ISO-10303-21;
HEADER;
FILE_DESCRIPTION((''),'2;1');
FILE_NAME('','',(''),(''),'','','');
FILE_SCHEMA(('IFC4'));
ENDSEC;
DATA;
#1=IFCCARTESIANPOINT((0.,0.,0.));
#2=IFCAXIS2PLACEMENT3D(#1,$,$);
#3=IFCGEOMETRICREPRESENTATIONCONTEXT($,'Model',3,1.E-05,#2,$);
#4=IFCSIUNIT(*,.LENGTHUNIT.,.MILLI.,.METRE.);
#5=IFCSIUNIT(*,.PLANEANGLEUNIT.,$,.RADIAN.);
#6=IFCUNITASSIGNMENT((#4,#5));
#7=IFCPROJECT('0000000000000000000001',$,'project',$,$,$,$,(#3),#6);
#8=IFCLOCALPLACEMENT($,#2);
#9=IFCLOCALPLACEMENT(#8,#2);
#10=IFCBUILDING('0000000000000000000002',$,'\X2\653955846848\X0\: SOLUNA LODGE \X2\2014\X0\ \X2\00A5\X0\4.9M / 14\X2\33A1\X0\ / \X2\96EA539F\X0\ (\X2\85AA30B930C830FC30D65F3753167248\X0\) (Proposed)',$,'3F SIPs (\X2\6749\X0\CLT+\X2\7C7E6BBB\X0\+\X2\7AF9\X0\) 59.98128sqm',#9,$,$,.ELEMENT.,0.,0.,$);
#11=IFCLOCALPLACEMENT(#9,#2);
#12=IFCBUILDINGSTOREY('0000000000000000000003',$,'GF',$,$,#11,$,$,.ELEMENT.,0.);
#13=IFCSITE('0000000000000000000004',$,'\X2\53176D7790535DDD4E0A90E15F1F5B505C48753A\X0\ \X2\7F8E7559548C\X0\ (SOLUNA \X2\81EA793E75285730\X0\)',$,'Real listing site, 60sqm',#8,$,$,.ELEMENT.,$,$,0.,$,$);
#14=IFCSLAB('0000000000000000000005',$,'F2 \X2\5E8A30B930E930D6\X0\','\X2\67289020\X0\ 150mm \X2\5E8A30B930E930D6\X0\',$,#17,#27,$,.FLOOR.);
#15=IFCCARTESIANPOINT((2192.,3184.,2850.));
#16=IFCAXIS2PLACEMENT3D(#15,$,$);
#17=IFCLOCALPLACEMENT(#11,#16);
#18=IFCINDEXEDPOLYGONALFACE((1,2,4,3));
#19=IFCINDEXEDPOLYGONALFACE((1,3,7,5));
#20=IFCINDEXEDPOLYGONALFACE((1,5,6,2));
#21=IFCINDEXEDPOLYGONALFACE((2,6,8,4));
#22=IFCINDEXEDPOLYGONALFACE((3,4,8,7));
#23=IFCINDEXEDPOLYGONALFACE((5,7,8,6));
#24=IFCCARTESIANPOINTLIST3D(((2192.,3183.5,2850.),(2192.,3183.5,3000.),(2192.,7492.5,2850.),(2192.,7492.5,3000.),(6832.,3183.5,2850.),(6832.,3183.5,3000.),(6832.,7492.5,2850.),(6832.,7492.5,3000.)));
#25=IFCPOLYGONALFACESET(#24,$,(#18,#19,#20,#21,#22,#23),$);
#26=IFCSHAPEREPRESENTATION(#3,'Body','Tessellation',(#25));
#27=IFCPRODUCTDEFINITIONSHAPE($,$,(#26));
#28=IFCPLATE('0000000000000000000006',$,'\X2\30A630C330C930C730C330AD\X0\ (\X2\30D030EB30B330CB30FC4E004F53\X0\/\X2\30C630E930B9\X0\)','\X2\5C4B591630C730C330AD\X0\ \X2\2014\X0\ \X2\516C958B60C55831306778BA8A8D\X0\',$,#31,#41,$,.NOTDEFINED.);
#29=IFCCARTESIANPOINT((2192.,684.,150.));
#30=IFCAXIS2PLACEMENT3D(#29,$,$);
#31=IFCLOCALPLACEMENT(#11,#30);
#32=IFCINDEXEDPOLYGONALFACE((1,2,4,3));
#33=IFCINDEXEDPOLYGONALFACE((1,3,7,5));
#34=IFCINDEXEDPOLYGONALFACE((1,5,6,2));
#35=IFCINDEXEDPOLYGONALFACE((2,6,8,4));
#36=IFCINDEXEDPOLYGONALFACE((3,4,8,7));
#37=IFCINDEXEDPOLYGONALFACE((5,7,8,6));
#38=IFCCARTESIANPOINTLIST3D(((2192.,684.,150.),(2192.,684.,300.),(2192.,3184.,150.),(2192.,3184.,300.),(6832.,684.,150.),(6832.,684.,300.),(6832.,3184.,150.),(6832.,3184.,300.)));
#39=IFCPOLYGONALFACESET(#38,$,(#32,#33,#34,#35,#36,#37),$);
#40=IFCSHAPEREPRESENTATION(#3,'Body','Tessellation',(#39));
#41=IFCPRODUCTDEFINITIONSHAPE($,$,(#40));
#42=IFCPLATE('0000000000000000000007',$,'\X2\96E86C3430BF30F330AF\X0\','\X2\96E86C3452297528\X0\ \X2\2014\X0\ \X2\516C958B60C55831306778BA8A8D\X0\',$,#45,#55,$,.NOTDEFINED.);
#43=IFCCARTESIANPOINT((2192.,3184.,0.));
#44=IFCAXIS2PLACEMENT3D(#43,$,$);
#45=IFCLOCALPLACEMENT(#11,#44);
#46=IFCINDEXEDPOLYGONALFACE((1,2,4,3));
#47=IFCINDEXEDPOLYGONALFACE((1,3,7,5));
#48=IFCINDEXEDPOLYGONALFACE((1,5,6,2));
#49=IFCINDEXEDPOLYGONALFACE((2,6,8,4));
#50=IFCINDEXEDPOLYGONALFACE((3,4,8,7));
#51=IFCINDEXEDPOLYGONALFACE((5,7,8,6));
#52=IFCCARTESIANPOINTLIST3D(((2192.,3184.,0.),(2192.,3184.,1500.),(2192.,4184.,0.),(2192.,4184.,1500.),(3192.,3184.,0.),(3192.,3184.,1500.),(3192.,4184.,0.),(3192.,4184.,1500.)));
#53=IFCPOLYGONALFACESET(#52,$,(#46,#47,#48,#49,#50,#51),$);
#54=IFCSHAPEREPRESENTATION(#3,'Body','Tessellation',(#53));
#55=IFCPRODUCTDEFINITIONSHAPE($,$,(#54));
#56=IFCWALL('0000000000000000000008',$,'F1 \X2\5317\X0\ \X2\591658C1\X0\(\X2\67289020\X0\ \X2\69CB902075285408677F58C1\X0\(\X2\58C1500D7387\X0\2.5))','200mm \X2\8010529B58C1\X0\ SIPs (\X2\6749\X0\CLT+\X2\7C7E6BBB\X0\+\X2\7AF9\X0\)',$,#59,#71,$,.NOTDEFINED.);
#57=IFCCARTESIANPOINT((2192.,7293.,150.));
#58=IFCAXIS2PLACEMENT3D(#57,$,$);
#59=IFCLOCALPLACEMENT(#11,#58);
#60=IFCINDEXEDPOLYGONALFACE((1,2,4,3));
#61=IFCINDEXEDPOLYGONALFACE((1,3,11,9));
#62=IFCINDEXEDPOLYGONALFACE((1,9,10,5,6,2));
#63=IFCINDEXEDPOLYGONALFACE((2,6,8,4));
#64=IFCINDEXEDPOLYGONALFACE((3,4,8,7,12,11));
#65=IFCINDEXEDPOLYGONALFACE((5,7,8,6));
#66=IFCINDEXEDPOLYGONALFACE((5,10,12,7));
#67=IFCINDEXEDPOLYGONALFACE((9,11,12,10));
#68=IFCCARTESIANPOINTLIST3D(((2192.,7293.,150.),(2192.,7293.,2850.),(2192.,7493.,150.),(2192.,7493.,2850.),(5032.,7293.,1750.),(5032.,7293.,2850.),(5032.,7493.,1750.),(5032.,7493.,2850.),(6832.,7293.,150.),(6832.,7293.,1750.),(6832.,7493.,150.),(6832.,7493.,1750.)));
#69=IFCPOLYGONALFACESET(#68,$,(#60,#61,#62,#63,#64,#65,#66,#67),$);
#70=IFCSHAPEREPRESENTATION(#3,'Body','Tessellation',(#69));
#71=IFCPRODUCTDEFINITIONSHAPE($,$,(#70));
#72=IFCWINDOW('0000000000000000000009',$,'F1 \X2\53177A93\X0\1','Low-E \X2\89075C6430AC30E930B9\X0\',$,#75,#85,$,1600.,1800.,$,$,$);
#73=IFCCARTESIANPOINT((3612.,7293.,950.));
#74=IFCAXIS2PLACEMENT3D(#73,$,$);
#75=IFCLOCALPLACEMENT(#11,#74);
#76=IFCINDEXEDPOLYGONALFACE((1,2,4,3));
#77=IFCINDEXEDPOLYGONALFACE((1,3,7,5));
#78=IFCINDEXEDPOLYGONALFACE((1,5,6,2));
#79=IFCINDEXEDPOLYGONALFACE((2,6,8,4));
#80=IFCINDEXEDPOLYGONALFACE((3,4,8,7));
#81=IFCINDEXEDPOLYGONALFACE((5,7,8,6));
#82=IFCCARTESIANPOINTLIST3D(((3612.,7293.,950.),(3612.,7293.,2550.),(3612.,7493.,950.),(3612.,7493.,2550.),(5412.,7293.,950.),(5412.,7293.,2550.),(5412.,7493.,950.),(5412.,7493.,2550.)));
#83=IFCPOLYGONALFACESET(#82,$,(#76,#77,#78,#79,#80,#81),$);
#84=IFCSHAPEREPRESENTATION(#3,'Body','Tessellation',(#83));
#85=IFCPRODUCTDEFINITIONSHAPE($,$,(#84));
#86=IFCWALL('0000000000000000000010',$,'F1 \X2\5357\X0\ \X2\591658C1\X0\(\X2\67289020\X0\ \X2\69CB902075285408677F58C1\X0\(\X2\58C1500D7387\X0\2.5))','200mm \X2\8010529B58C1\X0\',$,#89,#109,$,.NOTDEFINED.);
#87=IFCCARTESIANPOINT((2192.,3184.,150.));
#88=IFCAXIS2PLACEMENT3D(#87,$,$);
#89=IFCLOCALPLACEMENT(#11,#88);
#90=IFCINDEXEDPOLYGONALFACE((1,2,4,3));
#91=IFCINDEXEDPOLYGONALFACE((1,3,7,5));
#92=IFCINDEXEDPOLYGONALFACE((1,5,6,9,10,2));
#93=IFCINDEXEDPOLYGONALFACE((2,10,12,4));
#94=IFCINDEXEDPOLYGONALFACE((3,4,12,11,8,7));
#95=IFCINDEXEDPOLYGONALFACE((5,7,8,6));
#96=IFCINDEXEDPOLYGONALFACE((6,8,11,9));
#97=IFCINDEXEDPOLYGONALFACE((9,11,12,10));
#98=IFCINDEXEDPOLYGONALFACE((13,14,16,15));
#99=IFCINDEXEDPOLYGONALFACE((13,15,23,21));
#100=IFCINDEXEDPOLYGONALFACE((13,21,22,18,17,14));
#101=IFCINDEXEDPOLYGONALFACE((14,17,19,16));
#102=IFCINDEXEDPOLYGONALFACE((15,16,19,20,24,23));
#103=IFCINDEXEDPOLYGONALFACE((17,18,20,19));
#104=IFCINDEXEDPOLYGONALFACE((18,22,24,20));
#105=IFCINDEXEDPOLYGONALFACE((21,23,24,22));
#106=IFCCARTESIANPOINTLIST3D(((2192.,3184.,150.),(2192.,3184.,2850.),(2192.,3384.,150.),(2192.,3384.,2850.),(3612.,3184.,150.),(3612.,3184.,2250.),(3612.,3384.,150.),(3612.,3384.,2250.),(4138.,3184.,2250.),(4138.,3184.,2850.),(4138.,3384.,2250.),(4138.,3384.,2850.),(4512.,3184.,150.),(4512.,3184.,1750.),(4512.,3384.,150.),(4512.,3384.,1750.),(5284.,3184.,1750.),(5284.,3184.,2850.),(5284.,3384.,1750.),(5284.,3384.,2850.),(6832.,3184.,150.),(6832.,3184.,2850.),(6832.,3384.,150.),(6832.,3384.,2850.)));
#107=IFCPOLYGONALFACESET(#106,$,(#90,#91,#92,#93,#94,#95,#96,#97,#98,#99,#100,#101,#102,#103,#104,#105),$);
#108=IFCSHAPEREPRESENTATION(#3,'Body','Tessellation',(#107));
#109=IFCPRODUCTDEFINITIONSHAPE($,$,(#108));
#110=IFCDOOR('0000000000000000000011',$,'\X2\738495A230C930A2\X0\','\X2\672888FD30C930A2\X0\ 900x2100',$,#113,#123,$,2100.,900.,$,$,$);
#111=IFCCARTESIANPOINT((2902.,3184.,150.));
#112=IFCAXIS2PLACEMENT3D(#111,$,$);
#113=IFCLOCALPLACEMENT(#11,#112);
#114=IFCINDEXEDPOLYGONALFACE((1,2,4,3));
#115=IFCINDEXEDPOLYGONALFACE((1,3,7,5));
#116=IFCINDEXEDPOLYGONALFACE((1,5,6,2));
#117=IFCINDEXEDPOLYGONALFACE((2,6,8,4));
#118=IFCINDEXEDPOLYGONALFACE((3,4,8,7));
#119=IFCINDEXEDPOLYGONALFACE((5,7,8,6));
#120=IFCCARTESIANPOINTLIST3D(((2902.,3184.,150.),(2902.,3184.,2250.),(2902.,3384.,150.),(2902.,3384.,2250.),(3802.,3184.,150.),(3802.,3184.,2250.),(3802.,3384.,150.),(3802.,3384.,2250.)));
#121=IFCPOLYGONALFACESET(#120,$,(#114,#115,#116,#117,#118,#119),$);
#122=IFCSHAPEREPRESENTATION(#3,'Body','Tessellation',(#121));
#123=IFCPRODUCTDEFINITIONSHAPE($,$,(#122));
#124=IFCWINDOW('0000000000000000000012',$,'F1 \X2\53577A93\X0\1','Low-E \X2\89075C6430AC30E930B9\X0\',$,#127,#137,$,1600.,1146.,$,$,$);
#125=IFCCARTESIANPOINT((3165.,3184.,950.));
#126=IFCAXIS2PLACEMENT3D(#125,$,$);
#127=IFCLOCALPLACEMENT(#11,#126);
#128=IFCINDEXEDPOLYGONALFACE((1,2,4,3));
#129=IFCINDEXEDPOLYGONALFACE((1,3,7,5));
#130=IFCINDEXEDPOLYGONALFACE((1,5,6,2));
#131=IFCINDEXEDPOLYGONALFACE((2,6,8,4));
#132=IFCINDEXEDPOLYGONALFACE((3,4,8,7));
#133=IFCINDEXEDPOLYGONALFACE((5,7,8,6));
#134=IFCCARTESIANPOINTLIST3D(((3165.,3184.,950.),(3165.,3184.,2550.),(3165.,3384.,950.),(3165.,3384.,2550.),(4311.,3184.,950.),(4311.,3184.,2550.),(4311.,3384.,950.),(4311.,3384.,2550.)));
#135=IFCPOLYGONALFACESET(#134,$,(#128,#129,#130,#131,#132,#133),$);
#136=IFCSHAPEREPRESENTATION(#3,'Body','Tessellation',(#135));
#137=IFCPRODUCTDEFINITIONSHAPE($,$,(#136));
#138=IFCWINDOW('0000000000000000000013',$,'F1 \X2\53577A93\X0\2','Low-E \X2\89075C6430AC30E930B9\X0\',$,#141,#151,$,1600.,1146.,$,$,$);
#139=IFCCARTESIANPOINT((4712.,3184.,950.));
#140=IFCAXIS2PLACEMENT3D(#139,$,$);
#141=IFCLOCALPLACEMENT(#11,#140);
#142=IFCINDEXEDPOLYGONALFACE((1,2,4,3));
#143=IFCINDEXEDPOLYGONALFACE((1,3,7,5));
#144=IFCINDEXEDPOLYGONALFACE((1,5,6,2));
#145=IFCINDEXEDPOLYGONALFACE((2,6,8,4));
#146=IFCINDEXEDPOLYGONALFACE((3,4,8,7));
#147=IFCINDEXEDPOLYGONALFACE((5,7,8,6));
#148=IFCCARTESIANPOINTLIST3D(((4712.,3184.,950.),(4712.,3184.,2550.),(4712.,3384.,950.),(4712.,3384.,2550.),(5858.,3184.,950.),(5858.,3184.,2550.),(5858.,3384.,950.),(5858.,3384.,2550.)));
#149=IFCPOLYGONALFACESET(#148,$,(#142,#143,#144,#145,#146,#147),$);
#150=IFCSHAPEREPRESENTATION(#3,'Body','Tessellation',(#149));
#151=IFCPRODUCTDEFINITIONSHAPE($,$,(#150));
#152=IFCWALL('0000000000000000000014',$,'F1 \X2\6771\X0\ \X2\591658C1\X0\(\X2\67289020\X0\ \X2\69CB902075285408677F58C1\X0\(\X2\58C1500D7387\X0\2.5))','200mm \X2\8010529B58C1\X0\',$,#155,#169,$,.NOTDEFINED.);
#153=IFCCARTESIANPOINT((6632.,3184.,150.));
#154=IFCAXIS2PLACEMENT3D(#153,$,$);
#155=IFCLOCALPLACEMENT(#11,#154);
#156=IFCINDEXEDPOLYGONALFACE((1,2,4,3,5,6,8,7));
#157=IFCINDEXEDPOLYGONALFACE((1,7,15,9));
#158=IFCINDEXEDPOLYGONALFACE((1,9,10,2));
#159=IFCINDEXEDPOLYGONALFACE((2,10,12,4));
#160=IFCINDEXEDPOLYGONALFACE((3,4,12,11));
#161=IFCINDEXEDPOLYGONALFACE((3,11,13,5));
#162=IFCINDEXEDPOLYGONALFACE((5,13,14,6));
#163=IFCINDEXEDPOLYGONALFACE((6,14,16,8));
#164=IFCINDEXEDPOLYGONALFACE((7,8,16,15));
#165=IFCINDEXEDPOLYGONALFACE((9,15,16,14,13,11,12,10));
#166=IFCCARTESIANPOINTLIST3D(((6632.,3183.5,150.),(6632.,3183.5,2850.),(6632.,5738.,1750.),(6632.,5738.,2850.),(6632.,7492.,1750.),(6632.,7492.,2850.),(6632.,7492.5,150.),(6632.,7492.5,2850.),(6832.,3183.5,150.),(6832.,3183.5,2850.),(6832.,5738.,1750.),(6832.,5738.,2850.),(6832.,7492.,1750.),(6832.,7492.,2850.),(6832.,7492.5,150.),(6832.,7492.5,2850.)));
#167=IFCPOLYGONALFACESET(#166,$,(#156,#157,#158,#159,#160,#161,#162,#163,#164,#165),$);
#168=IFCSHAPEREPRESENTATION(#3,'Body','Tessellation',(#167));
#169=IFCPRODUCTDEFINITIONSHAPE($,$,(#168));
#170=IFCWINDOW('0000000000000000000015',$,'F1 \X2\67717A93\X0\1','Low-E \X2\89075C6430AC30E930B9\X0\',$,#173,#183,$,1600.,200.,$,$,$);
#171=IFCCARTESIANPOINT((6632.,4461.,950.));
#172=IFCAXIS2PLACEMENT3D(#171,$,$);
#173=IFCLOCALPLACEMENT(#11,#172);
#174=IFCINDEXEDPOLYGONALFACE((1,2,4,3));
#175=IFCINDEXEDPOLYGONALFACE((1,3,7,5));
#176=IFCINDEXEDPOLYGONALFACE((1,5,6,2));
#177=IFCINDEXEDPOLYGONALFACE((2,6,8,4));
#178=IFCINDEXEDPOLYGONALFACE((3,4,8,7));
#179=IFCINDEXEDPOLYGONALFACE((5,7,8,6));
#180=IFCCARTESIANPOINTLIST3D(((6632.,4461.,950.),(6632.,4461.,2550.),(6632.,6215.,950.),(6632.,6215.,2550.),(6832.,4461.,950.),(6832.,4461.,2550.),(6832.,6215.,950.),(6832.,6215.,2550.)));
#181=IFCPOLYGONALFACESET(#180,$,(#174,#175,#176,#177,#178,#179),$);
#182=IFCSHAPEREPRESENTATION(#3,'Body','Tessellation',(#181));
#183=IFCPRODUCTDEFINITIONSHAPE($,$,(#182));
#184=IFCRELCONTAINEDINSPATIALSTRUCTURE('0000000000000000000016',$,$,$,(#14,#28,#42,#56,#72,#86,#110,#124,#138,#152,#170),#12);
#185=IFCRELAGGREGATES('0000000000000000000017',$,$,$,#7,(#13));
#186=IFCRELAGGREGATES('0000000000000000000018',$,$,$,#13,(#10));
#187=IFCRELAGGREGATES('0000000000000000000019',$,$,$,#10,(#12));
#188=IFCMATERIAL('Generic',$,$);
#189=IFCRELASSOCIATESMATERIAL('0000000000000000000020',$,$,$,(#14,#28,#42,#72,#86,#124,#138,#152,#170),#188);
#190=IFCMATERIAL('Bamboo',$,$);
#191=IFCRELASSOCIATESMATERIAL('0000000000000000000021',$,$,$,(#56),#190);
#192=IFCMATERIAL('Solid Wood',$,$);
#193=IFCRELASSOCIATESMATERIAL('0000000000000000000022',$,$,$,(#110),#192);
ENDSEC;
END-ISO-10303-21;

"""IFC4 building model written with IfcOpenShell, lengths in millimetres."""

from ifc_helpers import new_model, si_unit, frame, frame_2d, origin, place, context, project, spatial, rectangle, extrude, material, element, fill, save


model = new_model("IFC4")

# Units and contexts
model_context = context("Model", 3, precision=1e-05, world=origin())
ifc_project = project(units=[si_unit("LENGTHUNIT", "METRE", prefix="MILLI"), si_unit("PLANEANGLEUNIT", "RADIAN")], contexts=[model_context])

# Site, building, storey
site_placement = place(None, origin())
site = spatial("IfcSite", under=ifc_project, at=site_placement, Name="北海道川上郡弟子屈町 美留和 (SOLUNA 自社用地)", ObjectType="Real listing site, 60sqm", CompositionType="ELEMENT", RefElevation=0.0)
building_placement = place(site_placement, origin())
building = spatial("IfcBuilding", under=site, at=building_placement, Name="改善案: SOLUNA LODGE — ¥4.9M / 14㎡ / 雪原 (薪ストーブ強化版) (Proposed)", ObjectType="3F SIPs (杉CLT+籾殻+竹) 59.98128sqm", CompositionType="ELEMENT", ElevationOfRefHeight=0.0, ElevationOfTerrain=0.0)
storey_placement = place(building_placement, origin())
storey = spatial("IfcBuildingStorey", under=building, at=storey_placement, Name="GF", CompositionType="ELEMENT", Elevation=0.0)

# Slab
ifc_material_1 = material(Name="Generic")
slab_1_placement = place(storey_placement, frame((2192.0, 3184.0, 2850.0)))
element("IfcSlab", 1, at=slab_1_placement, inside=storey, material=ifc_material_1, Name="F2 床スラブ", Description="木造 150mm 床スラブ", PredefinedType="FLOOR", context=model_context, shape_type="SweptSolid", body=[
    extrude(rectangle(XDim=4640.0, YDim=4309.0, at=frame_2d((2320.0, 2154.0))), frame((2192.0, 3184.0, 2850.0)), (0.0, 0.0, 1.0), 150.0),
])

# Plates
plate_1_placement = place(storey_placement, frame((2192.0, 684.0, 150.0)))
element("IfcPlate", 2, at=plate_1_placement, inside=storey, material=ifc_material_1, Name="ウッドデッキ (バルコニー一体/テラス)", Description="屋外デッキ — 公開情報で確認", PredefinedType="NOTDEFINED", context=model_context, shape_type="SweptSolid", body=[
    extrude(rectangle(XDim=4640.0, YDim=2500.0, at=frame_2d((2320.0, 1250.0))), frame((2192.0, 684.0, 150.0)), (0.0, 0.0, 1.0), 150.0),
])
plate_2_placement = place(storey_placement, frame((2192.0, 3184.0, 0.0)))
element("IfcPlate", 3, at=plate_2_placement, inside=storey, material=ifc_material_1, Name="雨水タンク", Description="雨水利用 — 公開情報で確認", PredefinedType="NOTDEFINED", context=model_context, shape_type="SweptSolid", body=[
    extrude(rectangle(XDim=1000.0, YDim=1000.0, at=frame_2d((500.0, 500.0))), frame((2192.0, 3184.0, 0.0)), (0.0, 0.0, 1.0), 1500.0),
])

# Wall, opening, window
ifc_material_2 = material(Name="Bamboo")
wall_1_placement = place(storey_placement, frame((2192.0, 7293.0, 150.0)))
wall_1 = element("IfcWall", 4, at=wall_1_placement, inside=storey, material=ifc_material_2, Name="F1 北 外壁(木造 構造用合板壁(壁倍率2.5))", Description="200mm 耐力壁 SIPs (杉CLT+籾殻+竹)", PredefinedType="NOTDEFINED", context=model_context, shape_type="SweptSolid", body=[
    extrude(rectangle(XDim=4640.0, YDim=200.0, at=frame_2d((2320.0, 100.0))), frame((2192.0, 7293.0, 150.0)), (0.0, 0.0, 1.0), 2700.0),
])
opening_1_placement = place(storey_placement, frame((3612.0, 7293.0, 950.0)))
opening_1 = element("IfcOpeningElement", 5, at=opening_1_placement, cuts=wall_1, PredefinedType="NOTDEFINED", context=model_context, shape_type="SweptSolid", body=[
    extrude(rectangle(XDim=1800.0, YDim=200.0, at=frame_2d((900.0, 100.0))), frame((3612.0, 7293.0, 950.0)), (0.0, 0.0, 1.0), 1600.0),
])
window_1_placement = place(storey_placement, frame((3612.0, 7293.0, 950.0)))
window_1 = element("IfcWindow", 6, at=window_1_placement, inside=storey, material=ifc_material_1, Name="F1 北窓1", Description="Low-E 複層ガラス", OverallHeight=1600.0, OverallWidth=1800.0, context=model_context, shape_type="SweptSolid", body=[
    extrude(rectangle(XDim=1800.0, YDim=200.0, at=frame_2d((900.0, 100.0))), frame((3612.0, 7293.0, 950.0)), (0.0, 0.0, 1.0), 1600.0),
])
fill(opening_1, window_1)

# Wall, openings, door, windows
wall_2_placement = place(storey_placement, frame((2192.0, 3184.0, 150.0)))
wall_2 = element("IfcWall", 7, at=wall_2_placement, inside=storey, material=ifc_material_1, Name="F1 南 外壁(木造 構造用合板壁(壁倍率2.5))", Description="200mm 耐力壁", PredefinedType="NOTDEFINED", context=model_context, shape_type="SweptSolid", body=[
    extrude(rectangle(XDim=4640.0, YDim=200.0, at=frame_2d((2320.0, 100.0))), frame((2192.0, 3184.0, 150.0)), (0.0, 0.0, 1.0), 2700.0),
])
opening_2_placement = place(storey_placement, frame((2902.0, 3184.0, 150.0)))
opening_2 = element("IfcOpeningElement", 8, at=opening_2_placement, cuts=wall_2, PredefinedType="NOTDEFINED", context=model_context, shape_type="SweptSolid", body=[
    extrude(rectangle(XDim=900.0, YDim=200.0, at=frame_2d((450.0, 100.0))), frame((2902.0, 3184.0, 150.0)), (0.0, 0.0, 1.0), 2100.0),
])
opening_3_placement = place(storey_placement, frame((3165.0, 3184.0, 950.0)))
opening_3 = element("IfcOpeningElement", 9, at=opening_3_placement, cuts=wall_2, PredefinedType="NOTDEFINED", context=model_context, shape_type="SweptSolid", body=[
    extrude(rectangle(XDim=1146.0, YDim=200.0, at=frame_2d((573.0, 100.0))), frame((3165.0, 3184.0, 950.0)), (0.0, 0.0, 1.0), 1600.0),
])
opening_4_placement = place(storey_placement, frame((4712.0, 3184.0, 950.0)))
opening_4 = element("IfcOpeningElement", 10, at=opening_4_placement, cuts=wall_2, PredefinedType="NOTDEFINED", context=model_context, shape_type="SweptSolid", body=[
    extrude(rectangle(XDim=1146.0, YDim=200.0, at=frame_2d((573.0, 100.0))), frame((4712.0, 3184.0, 950.0)), (0.0, 0.0, 1.0), 1600.0),
])
ifc_material_3 = material(Name="Solid Wood")
door_placement = place(storey_placement, frame((2902.0, 3184.0, 150.0)))
door = element("IfcDoor", 11, at=door_placement, inside=storey, material=ifc_material_3, Name="玄関ドア", Description="木製ドア 900x2100", OverallHeight=2100.0, OverallWidth=900.0, context=model_context, shape_type="SweptSolid", body=[
    extrude(rectangle(XDim=900.0, YDim=200.0, at=frame_2d((450.0, 100.0))), frame((2902.0, 3184.0, 150.0)), (0.0, 0.0, 1.0), 2100.0),
])
fill(opening_2, door)
window_2_placement = place(storey_placement, frame((3165.0, 3184.0, 950.0)))
window_2 = element("IfcWindow", 12, at=window_2_placement, inside=storey, material=ifc_material_1, Name="F1 南窓1", Description="Low-E 複層ガラス", OverallHeight=1600.0, OverallWidth=1146.0, context=model_context, shape_type="SweptSolid", body=[
    extrude(rectangle(XDim=1146.0, YDim=200.0, at=frame_2d((573.0, 100.0))), frame((3165.0, 3184.0, 950.0)), (0.0, 0.0, 1.0), 1600.0),
])
fill(opening_3, window_2)
window_3_placement = place(storey_placement, frame((4712.0, 3184.0, 950.0)))
window_3 = element("IfcWindow", 13, at=window_3_placement, inside=storey, material=ifc_material_1, Name="F1 南窓2", Description="Low-E 複層ガラス", OverallHeight=1600.0, OverallWidth=1146.0, context=model_context, shape_type="SweptSolid", body=[
    extrude(rectangle(XDim=1146.0, YDim=200.0, at=frame_2d((573.0, 100.0))), frame((4712.0, 3184.0, 950.0)), (0.0, 0.0, 1.0), 1600.0),
])
fill(opening_4, window_3)

# Wall, opening, window
wall_3_placement = place(storey_placement, frame((6632.0, 3184.0, 150.0)))
wall_3 = element("IfcWall", 14, at=wall_3_placement, inside=storey, material=ifc_material_1, Name="F1 東 外壁(木造 構造用合板壁(壁倍率2.5))", Description="200mm 耐力壁", PredefinedType="NOTDEFINED", context=model_context, shape_type="SweptSolid", body=[
    extrude(rectangle(XDim=200.0, YDim=4309.0, at=frame_2d((100.0, 2154.0))), frame((6632.0, 3184.0, 150.0)), (0.0, 0.0, 1.0), 2700.0),
])
opening_5_placement = place(storey_placement, frame((6632.0, 4461.0, 950.0)))
opening_5 = element("IfcOpeningElement", 15, at=opening_5_placement, cuts=wall_3, PredefinedType="NOTDEFINED", context=model_context, shape_type="SweptSolid", body=[
    extrude(rectangle(XDim=200.0, YDim=1754.0, at=frame_2d((100.0, 877.0))), frame((6632.0, 4461.0, 950.0)), (0.0, 0.0, 1.0), 1600.0),
])
window_4_placement = place(storey_placement, frame((6632.0, 4461.0, 950.0)))
window_4 = element("IfcWindow", 16, at=window_4_placement, inside=storey, material=ifc_material_1, Name="F1 東窓1", Description="Low-E 複層ガラス", OverallHeight=1600.0, OverallWidth=200.0, context=model_context, shape_type="SweptSolid", body=[
    extrude(rectangle(XDim=200.0, YDim=1754.0, at=frame_2d((100.0, 877.0))), frame((6632.0, 4461.0, 950.0)), (0.0, 0.0, 1.0), 1600.0),
])
fill(opening_5, window_4)

save(model, "model.ifc")
